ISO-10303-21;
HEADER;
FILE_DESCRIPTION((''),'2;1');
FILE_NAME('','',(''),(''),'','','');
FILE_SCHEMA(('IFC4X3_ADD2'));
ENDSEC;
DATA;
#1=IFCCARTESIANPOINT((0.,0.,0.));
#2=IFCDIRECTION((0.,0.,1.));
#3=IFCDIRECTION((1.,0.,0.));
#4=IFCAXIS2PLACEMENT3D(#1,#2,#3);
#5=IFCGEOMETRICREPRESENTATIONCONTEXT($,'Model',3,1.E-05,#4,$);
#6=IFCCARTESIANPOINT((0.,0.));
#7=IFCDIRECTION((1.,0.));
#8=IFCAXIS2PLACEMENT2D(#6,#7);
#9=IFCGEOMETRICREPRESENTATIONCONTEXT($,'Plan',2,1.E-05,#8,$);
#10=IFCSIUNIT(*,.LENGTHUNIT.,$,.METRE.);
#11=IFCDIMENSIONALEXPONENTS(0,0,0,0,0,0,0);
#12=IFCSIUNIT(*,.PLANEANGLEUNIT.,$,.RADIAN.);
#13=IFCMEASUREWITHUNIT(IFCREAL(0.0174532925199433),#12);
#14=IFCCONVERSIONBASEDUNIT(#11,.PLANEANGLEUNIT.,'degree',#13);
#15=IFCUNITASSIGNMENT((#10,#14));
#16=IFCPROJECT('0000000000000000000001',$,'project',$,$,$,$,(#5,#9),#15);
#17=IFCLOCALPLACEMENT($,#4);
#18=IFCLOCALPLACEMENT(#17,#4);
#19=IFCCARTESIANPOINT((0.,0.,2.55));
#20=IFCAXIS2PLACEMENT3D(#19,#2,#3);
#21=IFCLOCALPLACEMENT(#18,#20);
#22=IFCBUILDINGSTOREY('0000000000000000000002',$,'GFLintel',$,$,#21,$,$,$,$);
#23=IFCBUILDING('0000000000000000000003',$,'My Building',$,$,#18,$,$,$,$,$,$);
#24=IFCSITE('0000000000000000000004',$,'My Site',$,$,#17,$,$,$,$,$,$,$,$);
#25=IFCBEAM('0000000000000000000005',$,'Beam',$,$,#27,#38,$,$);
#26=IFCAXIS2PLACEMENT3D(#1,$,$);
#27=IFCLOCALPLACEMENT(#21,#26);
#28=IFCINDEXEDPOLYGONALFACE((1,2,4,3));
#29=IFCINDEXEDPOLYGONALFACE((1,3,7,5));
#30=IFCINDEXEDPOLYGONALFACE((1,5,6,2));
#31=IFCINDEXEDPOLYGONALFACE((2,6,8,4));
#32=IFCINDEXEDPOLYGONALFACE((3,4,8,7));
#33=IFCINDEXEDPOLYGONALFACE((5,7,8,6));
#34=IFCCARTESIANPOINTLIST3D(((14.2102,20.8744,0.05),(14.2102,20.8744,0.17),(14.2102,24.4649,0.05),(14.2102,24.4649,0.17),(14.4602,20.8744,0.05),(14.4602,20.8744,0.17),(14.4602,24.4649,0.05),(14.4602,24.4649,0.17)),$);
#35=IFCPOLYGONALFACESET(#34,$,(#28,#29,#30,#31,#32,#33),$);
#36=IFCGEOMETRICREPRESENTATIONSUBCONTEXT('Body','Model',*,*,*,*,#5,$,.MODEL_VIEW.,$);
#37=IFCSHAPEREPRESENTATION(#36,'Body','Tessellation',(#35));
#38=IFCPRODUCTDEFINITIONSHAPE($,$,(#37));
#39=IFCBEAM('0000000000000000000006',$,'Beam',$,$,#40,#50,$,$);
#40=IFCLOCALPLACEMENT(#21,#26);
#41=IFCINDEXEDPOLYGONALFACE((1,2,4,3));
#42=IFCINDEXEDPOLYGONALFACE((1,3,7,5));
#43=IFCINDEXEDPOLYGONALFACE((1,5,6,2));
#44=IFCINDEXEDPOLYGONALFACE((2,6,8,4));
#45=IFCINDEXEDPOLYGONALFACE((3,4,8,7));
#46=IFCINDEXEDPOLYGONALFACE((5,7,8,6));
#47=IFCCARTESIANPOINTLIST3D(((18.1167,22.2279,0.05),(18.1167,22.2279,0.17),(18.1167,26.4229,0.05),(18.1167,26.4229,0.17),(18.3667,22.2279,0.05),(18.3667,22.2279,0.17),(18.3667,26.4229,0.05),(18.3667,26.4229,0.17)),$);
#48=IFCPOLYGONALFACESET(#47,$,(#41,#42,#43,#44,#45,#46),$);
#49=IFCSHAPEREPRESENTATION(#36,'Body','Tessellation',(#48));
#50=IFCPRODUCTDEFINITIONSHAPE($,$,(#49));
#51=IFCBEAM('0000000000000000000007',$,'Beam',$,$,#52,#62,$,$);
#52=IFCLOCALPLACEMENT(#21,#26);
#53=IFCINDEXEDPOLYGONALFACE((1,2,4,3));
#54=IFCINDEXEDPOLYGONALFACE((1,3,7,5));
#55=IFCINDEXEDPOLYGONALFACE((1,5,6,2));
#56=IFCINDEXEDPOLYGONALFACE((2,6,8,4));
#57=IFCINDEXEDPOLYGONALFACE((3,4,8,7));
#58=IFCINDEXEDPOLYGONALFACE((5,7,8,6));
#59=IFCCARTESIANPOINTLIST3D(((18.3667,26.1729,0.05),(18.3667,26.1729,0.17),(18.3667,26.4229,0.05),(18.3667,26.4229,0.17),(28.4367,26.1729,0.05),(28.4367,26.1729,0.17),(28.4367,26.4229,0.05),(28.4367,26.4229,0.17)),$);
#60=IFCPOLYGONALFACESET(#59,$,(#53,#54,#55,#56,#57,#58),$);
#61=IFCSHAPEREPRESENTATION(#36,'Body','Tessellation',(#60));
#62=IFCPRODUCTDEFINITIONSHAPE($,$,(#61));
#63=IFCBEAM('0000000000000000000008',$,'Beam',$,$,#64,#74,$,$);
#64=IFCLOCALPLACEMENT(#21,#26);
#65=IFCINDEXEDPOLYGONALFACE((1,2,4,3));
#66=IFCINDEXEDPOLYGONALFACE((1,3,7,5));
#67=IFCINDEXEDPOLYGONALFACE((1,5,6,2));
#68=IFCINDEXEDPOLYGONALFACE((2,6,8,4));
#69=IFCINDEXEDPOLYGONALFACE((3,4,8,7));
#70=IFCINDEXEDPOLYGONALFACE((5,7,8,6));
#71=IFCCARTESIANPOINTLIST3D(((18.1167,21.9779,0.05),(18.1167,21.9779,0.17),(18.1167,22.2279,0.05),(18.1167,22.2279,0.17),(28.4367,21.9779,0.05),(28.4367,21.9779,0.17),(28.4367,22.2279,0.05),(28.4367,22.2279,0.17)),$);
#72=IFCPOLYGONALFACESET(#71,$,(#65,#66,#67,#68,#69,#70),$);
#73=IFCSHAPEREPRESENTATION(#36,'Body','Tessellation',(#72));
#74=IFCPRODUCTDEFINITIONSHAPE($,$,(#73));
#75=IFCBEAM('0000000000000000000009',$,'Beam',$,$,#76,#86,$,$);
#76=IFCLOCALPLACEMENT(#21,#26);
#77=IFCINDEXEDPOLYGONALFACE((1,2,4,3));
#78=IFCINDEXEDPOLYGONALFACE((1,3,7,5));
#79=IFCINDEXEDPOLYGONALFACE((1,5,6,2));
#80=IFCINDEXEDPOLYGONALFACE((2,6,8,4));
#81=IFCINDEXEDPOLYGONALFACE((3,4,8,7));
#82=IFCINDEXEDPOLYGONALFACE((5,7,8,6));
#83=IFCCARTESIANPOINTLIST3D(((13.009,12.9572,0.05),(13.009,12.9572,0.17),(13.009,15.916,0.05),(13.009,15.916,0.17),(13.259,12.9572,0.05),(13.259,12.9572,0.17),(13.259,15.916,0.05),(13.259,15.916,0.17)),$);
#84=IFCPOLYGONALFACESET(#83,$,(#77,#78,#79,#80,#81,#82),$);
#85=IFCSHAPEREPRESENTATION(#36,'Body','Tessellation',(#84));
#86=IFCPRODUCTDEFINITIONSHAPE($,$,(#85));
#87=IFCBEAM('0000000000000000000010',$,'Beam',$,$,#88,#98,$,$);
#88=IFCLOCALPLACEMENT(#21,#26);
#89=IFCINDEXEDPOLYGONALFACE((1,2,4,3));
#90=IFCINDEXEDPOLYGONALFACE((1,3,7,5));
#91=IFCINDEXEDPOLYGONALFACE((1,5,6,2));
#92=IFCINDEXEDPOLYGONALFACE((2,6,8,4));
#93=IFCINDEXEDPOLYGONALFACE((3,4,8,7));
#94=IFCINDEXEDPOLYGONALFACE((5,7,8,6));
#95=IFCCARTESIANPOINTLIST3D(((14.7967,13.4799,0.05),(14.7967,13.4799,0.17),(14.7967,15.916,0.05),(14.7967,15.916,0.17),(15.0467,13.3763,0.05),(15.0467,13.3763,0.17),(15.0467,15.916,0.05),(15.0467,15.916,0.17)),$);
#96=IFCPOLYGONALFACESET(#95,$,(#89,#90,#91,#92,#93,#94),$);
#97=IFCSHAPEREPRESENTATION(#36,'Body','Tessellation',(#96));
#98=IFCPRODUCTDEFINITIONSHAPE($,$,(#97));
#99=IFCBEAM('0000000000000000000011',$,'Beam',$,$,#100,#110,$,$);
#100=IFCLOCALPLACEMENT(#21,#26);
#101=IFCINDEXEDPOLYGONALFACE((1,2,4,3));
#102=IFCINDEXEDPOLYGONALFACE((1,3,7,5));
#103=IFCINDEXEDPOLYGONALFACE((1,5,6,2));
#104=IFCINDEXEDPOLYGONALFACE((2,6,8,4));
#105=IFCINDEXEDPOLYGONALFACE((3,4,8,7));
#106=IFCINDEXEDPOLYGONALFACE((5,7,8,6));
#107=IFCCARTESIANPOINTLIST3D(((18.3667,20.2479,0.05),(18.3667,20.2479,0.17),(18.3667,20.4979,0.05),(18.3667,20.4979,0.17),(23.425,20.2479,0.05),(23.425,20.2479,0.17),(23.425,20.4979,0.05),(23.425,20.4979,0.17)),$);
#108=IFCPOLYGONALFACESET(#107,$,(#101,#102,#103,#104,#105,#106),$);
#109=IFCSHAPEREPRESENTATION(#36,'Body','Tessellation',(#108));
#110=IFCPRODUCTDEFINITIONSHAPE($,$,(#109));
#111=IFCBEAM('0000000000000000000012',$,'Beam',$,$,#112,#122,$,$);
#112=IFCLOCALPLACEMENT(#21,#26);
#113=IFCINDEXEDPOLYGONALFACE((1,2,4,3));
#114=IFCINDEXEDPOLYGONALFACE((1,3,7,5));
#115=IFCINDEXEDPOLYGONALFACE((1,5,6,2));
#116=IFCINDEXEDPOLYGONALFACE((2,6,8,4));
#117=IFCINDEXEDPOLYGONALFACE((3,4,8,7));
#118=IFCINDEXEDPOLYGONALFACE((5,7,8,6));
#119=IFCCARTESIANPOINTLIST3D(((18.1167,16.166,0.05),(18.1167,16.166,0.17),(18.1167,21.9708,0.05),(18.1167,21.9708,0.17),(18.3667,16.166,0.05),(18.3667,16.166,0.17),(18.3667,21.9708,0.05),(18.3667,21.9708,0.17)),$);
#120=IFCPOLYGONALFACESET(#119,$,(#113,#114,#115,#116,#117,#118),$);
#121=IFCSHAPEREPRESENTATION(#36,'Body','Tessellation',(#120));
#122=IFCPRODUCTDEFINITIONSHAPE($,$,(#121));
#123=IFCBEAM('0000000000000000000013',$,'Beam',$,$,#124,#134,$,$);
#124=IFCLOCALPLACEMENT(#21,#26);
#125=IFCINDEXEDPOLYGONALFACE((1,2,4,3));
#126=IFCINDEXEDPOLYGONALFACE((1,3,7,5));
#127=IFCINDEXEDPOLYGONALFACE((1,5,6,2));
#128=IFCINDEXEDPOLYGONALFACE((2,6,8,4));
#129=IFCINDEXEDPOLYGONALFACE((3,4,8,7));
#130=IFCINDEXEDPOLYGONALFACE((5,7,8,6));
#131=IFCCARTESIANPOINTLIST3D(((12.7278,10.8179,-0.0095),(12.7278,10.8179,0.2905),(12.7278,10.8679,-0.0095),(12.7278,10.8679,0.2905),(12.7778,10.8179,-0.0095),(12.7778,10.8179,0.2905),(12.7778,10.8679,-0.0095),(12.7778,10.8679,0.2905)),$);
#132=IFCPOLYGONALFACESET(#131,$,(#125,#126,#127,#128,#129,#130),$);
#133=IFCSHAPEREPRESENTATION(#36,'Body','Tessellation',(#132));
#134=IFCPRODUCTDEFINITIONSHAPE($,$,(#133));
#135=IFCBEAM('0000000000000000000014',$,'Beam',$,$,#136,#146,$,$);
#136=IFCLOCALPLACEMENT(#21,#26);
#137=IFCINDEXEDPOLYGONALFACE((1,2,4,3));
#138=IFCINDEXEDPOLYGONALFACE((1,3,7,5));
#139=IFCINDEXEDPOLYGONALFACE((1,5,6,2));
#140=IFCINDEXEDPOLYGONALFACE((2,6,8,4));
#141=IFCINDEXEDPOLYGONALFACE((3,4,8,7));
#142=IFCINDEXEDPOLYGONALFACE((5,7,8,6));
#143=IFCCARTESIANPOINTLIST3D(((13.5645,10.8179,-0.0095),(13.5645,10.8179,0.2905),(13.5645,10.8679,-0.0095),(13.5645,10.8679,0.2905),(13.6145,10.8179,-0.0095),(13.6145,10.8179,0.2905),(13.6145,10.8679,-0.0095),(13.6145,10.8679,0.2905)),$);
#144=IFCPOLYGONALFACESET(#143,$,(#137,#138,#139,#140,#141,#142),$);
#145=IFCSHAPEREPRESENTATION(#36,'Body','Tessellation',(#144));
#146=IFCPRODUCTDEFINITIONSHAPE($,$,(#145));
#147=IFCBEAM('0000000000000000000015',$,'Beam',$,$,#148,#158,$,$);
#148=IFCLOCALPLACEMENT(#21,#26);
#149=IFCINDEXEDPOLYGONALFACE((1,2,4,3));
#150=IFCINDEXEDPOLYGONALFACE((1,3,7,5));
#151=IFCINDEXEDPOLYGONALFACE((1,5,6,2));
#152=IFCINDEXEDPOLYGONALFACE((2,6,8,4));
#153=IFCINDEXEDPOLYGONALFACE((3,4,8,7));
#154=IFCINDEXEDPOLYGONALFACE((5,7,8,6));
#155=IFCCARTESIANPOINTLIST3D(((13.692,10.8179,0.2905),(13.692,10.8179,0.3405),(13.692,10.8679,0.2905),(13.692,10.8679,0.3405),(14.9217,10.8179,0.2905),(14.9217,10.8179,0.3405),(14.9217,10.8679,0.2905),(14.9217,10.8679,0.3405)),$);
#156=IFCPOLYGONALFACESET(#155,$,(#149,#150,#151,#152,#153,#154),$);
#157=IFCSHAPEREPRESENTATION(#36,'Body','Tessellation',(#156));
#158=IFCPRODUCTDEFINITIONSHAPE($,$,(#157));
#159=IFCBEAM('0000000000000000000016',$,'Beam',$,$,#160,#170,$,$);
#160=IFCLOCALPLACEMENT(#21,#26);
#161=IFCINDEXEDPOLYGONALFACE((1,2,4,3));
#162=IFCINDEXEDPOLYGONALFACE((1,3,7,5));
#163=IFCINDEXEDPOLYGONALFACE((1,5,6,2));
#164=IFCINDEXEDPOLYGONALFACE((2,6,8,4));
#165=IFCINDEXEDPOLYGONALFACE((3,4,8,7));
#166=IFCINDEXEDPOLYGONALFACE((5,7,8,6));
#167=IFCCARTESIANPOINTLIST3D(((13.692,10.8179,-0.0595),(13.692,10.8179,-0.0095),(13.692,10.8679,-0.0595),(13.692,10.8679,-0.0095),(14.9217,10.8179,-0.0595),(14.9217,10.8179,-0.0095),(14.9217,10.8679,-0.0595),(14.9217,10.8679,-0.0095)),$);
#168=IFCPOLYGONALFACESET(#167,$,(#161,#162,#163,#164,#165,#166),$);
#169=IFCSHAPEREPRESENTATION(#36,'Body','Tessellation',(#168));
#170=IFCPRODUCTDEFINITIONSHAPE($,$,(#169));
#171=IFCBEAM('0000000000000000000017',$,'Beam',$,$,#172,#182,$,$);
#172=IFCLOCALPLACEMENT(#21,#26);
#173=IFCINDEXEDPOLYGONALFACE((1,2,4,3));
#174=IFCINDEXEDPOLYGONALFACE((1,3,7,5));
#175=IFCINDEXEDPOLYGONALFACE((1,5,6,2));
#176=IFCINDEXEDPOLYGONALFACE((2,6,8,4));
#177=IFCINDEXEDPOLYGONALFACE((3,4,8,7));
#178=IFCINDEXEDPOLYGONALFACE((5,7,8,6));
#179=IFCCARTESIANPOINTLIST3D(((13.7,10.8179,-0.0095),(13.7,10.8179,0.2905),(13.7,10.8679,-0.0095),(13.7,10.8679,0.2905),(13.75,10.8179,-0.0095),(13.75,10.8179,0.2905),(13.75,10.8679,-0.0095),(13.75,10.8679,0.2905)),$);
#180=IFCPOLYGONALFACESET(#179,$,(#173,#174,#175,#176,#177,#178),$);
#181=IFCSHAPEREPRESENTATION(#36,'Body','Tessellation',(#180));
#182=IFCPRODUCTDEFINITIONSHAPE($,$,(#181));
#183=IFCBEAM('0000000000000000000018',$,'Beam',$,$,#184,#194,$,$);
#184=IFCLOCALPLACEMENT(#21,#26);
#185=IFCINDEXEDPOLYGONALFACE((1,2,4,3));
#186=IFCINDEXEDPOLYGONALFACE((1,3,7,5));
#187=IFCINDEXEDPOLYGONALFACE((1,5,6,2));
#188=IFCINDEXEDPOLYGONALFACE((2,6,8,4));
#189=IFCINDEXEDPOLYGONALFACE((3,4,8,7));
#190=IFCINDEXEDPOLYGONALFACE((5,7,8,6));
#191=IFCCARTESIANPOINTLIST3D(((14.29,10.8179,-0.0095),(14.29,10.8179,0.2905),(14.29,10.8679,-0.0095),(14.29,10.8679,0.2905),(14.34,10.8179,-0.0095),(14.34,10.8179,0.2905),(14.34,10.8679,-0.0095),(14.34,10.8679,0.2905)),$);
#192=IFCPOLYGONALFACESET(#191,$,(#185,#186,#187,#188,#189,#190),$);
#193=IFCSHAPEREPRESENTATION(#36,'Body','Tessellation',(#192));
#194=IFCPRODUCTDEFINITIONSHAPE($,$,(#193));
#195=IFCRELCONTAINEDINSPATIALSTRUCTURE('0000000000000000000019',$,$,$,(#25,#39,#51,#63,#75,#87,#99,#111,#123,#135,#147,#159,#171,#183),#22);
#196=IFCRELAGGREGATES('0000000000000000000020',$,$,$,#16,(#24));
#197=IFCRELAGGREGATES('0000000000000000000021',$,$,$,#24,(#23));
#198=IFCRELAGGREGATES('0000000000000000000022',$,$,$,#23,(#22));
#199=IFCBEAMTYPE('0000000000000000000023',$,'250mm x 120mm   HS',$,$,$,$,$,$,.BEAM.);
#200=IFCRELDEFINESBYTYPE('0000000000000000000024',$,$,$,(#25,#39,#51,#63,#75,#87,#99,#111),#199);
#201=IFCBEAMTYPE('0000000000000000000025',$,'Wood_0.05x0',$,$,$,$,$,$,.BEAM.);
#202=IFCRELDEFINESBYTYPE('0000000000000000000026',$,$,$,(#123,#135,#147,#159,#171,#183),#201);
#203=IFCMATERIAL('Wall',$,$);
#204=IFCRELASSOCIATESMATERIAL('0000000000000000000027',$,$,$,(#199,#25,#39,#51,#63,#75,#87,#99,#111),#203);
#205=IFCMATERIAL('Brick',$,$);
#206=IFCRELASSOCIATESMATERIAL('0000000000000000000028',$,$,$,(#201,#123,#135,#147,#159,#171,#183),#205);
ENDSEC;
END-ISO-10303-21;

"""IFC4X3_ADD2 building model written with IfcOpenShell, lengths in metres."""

from ifc_helpers import new_model, entity, si_unit, converted_unit, frame, origin_with_axes, origin_2d_with_axis, place, context, subcontext, project, spatial, rectangle, extrude, clip, halfspace, material, material_profile, profile_set, profile_usage, type_object, element, save


model = new_model("IFC4X3_ADD2")

# Units and contexts
model_context = context("Model", 3, precision=1e-05, world=origin_with_axes())
plan_context = context("Plan", 2, precision=1e-05, world=origin_2d_with_axis())
body_context = subcontext(model_context, "Body", "Model", "MODEL_VIEW")
ifc_project = project(units=[si_unit("LENGTHUNIT", "METRE"), converted_unit("PLANEANGLEUNIT", "degree", entity("IfcReal", 0.0174532925199433), si_unit("PLANEANGLEUNIT", "RADIAN"), dimensions=[0, 0, 0, 0, 0, 0, 0])], contexts=[model_context, plan_context])

# Site, building, storey
site_placement = place(None, origin_with_axes())
site = spatial("IfcSite", under=ifc_project, at=site_placement, Name="My Site")
building_placement = place(site_placement, origin_with_axes())
building = spatial("IfcBuilding", under=site, at=building_placement, Name="My Building")
storey_placement = place(building_placement, frame((0.0, 0.0, 2.55), z_axis=(0.0, 0.0, 1.0), x_axis=(1.0, 0.0, 0.0)))
storey = spatial("IfcBuildingStorey", under=building, at=storey_placement, Name="GFLintel")

# Beams
ifc_material_1 = material(Name="Wall")
ifc_material_profile_1 = material_profile(ifc_material_1, rectangle(XDim=0.25, YDim=0.12))
ifc_profile_set_1 = profile_set([ifc_material_profile_1], Name="concrete")
ifc_profile_usage_1 = profile_usage(ifc_profile_set_1, cardinal=5)
beam_type_1 = type_object("IfcBeamType", Name="250mm x 120mm   HS", PredefinedType="BEAM", material=ifc_profile_set_1)
beam_1_placement = place(storey_placement, frame((14.3352, 24.4649, 0.11), z_axis=(0.0, -1.0, 0.0), x_axis=(1.0, 0.0, 0.0)))
element("IfcBeam", 1, at=beam_1_placement, inside=storey, type_object=beam_type_1, material=ifc_profile_usage_1, Name="Beam", context=body_context, shape_type="SweptSolid", body=[
    extrude(rectangle(XDim=0.25, YDim=0.12), origin_with_axes(), (0.0, 0.0, 1.0), 3.5905),
])
ifc_profile_usage_2 = profile_usage(ifc_profile_set_1, cardinal=5)
beam_2_placement = place(storey_placement, frame((18.2417, 26.4229, 0.11), z_axis=(0.0, -1.0, 0.0), x_axis=(1.0, 0.0, 0.0)))
element("IfcBeam", 2, at=beam_2_placement, inside=storey, type_object=beam_type_1, material=ifc_profile_usage_2, Name="Beam", context=body_context, shape_type="SweptSolid", body=[
    extrude(rectangle(XDim=0.25, YDim=0.12), origin_with_axes(), (0.0, 0.0, 1.0), 4.195),
])
ifc_profile_usage_3 = profile_usage(ifc_profile_set_1, cardinal=5)
beam_3_placement = place(storey_placement, frame((18.3667, 26.2979, 0.11), z_axis=(1.0, 0.0, 0.0), x_axis=(0.0, 1.0, 0.0)))
element("IfcBeam", 3, at=beam_3_placement, inside=storey, type_object=beam_type_1, material=ifc_profile_usage_3, Name="Beam", context=body_context, shape_type="SweptSolid", body=[
    extrude(rectangle(XDim=0.25, YDim=0.12), origin_with_axes(), (0.0, 0.0, 1.0), 10.07),
])
ifc_profile_usage_4 = profile_usage(ifc_profile_set_1, cardinal=5)
beam_4_placement = place(storey_placement, frame((18.1167, 22.1029, 0.11), z_axis=(1.0, 0.0, 0.0), x_axis=(0.0, 1.0, 0.0)))
element("IfcBeam", 4, at=beam_4_placement, inside=storey, type_object=beam_type_1, material=ifc_profile_usage_4, Name="Beam", context=body_context, shape_type="SweptSolid", body=[
    extrude(rectangle(XDim=0.25, YDim=0.12), origin_with_axes(), (0.0, 0.0, 1.0), 10.32),
])
ifc_profile_usage_5 = profile_usage(ifc_profile_set_1, cardinal=5)
beam_5_placement = place(storey_placement, frame((13.134, 15.916, 0.11), z_axis=(0.0, -1.0, 0.0), x_axis=(1.0, 0.0, 0.0)))
element("IfcBeam", 5, at=beam_5_placement, inside=storey, type_object=beam_type_1, material=ifc_profile_usage_5, Name="Beam", context=body_context, shape_type="SweptSolid", body=[
    extrude(rectangle(XDim=0.25, YDim=0.12), origin_with_axes(), (0.0, 0.0, 1.0), 2.9588),
])
ifc_profile_usage_6 = profile_usage(ifc_profile_set_1, cardinal=5)
beam_6_placement = place(storey_placement, frame((14.9217, 15.916, 0.11), z_axis=(0.0, -1.0, 0.0), x_axis=(1.0, 0.0, 0.0)))
element("IfcBeam", 6, at=beam_6_placement, inside=storey, type_object=beam_type_1, material=ifc_profile_usage_6, Name="Beam", context=body_context, shape_type="Clipping", body=[
    clip(extrude(rectangle(XDim=0.25, YDim=0.12), origin_with_axes(), (0.0, 0.0, 1.0), 2.9147), halfspace(frame((0.125, -2.66, 2.5397), z_axis=(-0.382688, 0.0, 0.923878), x_axis=(0.0, 1.0, 0.0)), False)),
])
ifc_profile_usage_7 = profile_usage(ifc_profile_set_1, cardinal=5)
beam_7_placement = place(storey_placement, frame((18.3667, 20.3729, 0.11), z_axis=(1.0, 0.0, 0.0), x_axis=(0.0, 1.0, 0.0)))
element("IfcBeam", 7, at=beam_7_placement, inside=storey, type_object=beam_type_1, material=ifc_profile_usage_7, Name="Beam", context=body_context, shape_type="SweptSolid", body=[
    extrude(rectangle(XDim=0.25, YDim=0.12), origin_with_axes(), (0.0, 0.0, 1.0), 5.0583),
])
ifc_profile_usage_8 = profile_usage(ifc_profile_set_1, cardinal=5)
beam_8_placement = place(storey_placement, frame((18.2417, 21.9708, 0.11), z_axis=(0.0, -1.0, 0.0), x_axis=(1.0, 0.0, 0.0)))
element("IfcBeam", 8, at=beam_8_placement, inside=storey, type_object=beam_type_1, material=ifc_profile_usage_8, Name="Beam", context=body_context, shape_type="SweptSolid", body=[
    extrude(rectangle(XDim=0.25, YDim=0.12), origin_with_axes(), (0.0, 0.0, 1.0), 5.8048),
])
ifc_material_2 = material(Name="Brick")
ifc_material_profile_2 = material_profile(ifc_material_2, rectangle(XDim=0.05, YDim=0.05))
ifc_profile_set_2 = profile_set([ifc_material_profile_2])
ifc_profile_usage_9 = profile_usage(ifc_profile_set_2, cardinal=5)
beam_type_2 = type_object("IfcBeamType", Name="Wood_0.05x0", PredefinedType="BEAM", material=ifc_profile_set_2)
beam_9_placement = place(storey_placement, frame((12.7528, 10.8429, -0.0095), z_axis=(-0.000001, 0.0, 1.0), x_axis=(0.0, 1.0, 0.0)))
element("IfcBeam", 9, at=beam_9_placement, inside=storey, type_object=beam_type_2, material=ifc_profile_usage_9, Name="Beam", context=body_context, shape_type="SweptSolid", body=[
    extrude(rectangle(XDim=0.05, YDim=0.05), origin_with_axes(), (0.0, 0.0, 1.0), 0.3),
])
ifc_profile_usage_10 = profile_usage(ifc_profile_set_2, cardinal=5)
beam_10_placement = place(storey_placement, frame((13.5895, 10.8429, -0.0095), z_axis=(-0.000001, 0.0, 1.0), x_axis=(0.0, 1.0, 0.0)))
element("IfcBeam", 10, at=beam_10_placement, inside=storey, type_object=beam_type_2, material=ifc_profile_usage_10, Name="Beam", context=body_context, shape_type="SweptSolid", body=[
    extrude(rectangle(XDim=0.05, YDim=0.05), origin_with_axes(), (0.0, 0.0, 1.0), 0.3),
])
ifc_profile_usage_11 = profile_usage(ifc_profile_set_2, cardinal=5)
beam_11_placement = place(storey_placement, frame((13.692, 10.8429, 0.3155), z_axis=(1.0, 0.0, 0.000001), x_axis=(0.0, 1.0, 0.0)))
element("IfcBeam", 11, at=beam_11_placement, inside=storey, type_object=beam_type_2, material=ifc_profile_usage_11, Name="Beam", context=body_context, shape_type="SweptSolid", body=[
    extrude(rectangle(XDim=0.05, YDim=0.05), origin_with_axes(), (0.0, 0.0, 1.0), 1.2297),
])
ifc_profile_usage_12 = profile_usage(ifc_profile_set_2, cardinal=5)
beam_12_placement = place(storey_placement, frame((13.692, 10.8429, -0.0345), z_axis=(1.0, 0.0, 0.000001), x_axis=(0.0, 1.0, 0.0)))
element("IfcBeam", 12, at=beam_12_placement, inside=storey, type_object=beam_type_2, material=ifc_profile_usage_12, Name="Beam", context=body_context, shape_type="SweptSolid", body=[
    extrude(rectangle(XDim=0.05, YDim=0.05), origin_with_axes(), (0.0, 0.0, 1.0), 1.2297),
])
ifc_profile_usage_13 = profile_usage(ifc_profile_set_2, cardinal=5)
beam_13_placement = place(storey_placement, frame((13.725, 10.8429, -0.0095), z_axis=(-0.000001, 0.0, 1.0), x_axis=(0.0, 1.0, 0.0)))
element("IfcBeam", 13, at=beam_13_placement, inside=storey, type_object=beam_type_2, material=ifc_profile_usage_13, Name="Beam", context=body_context, shape_type="SweptSolid", body=[
    extrude(rectangle(XDim=0.05, YDim=0.05), origin_with_axes(), (0.0, 0.0, 1.0), 0.3),
])
ifc_profile_usage_14 = profile_usage(ifc_profile_set_2, cardinal=5)
beam_14_placement = place(storey_placement, frame((14.315, 10.8429, -0.0095), z_axis=(-0.000001, 0.0, 1.0), x_axis=(0.0, 1.0, 0.0)))
element("IfcBeam", 14, at=beam_14_placement, inside=storey, type_object=beam_type_2, material=ifc_profile_usage_14, Name="Beam", context=body_context, shape_type="SweptSolid", body=[
    extrude(rectangle(XDim=0.05, YDim=0.05), origin_with_axes(), (0.0, 0.0, 1.0), 0.3),
])

save(model, "model.ifc")
